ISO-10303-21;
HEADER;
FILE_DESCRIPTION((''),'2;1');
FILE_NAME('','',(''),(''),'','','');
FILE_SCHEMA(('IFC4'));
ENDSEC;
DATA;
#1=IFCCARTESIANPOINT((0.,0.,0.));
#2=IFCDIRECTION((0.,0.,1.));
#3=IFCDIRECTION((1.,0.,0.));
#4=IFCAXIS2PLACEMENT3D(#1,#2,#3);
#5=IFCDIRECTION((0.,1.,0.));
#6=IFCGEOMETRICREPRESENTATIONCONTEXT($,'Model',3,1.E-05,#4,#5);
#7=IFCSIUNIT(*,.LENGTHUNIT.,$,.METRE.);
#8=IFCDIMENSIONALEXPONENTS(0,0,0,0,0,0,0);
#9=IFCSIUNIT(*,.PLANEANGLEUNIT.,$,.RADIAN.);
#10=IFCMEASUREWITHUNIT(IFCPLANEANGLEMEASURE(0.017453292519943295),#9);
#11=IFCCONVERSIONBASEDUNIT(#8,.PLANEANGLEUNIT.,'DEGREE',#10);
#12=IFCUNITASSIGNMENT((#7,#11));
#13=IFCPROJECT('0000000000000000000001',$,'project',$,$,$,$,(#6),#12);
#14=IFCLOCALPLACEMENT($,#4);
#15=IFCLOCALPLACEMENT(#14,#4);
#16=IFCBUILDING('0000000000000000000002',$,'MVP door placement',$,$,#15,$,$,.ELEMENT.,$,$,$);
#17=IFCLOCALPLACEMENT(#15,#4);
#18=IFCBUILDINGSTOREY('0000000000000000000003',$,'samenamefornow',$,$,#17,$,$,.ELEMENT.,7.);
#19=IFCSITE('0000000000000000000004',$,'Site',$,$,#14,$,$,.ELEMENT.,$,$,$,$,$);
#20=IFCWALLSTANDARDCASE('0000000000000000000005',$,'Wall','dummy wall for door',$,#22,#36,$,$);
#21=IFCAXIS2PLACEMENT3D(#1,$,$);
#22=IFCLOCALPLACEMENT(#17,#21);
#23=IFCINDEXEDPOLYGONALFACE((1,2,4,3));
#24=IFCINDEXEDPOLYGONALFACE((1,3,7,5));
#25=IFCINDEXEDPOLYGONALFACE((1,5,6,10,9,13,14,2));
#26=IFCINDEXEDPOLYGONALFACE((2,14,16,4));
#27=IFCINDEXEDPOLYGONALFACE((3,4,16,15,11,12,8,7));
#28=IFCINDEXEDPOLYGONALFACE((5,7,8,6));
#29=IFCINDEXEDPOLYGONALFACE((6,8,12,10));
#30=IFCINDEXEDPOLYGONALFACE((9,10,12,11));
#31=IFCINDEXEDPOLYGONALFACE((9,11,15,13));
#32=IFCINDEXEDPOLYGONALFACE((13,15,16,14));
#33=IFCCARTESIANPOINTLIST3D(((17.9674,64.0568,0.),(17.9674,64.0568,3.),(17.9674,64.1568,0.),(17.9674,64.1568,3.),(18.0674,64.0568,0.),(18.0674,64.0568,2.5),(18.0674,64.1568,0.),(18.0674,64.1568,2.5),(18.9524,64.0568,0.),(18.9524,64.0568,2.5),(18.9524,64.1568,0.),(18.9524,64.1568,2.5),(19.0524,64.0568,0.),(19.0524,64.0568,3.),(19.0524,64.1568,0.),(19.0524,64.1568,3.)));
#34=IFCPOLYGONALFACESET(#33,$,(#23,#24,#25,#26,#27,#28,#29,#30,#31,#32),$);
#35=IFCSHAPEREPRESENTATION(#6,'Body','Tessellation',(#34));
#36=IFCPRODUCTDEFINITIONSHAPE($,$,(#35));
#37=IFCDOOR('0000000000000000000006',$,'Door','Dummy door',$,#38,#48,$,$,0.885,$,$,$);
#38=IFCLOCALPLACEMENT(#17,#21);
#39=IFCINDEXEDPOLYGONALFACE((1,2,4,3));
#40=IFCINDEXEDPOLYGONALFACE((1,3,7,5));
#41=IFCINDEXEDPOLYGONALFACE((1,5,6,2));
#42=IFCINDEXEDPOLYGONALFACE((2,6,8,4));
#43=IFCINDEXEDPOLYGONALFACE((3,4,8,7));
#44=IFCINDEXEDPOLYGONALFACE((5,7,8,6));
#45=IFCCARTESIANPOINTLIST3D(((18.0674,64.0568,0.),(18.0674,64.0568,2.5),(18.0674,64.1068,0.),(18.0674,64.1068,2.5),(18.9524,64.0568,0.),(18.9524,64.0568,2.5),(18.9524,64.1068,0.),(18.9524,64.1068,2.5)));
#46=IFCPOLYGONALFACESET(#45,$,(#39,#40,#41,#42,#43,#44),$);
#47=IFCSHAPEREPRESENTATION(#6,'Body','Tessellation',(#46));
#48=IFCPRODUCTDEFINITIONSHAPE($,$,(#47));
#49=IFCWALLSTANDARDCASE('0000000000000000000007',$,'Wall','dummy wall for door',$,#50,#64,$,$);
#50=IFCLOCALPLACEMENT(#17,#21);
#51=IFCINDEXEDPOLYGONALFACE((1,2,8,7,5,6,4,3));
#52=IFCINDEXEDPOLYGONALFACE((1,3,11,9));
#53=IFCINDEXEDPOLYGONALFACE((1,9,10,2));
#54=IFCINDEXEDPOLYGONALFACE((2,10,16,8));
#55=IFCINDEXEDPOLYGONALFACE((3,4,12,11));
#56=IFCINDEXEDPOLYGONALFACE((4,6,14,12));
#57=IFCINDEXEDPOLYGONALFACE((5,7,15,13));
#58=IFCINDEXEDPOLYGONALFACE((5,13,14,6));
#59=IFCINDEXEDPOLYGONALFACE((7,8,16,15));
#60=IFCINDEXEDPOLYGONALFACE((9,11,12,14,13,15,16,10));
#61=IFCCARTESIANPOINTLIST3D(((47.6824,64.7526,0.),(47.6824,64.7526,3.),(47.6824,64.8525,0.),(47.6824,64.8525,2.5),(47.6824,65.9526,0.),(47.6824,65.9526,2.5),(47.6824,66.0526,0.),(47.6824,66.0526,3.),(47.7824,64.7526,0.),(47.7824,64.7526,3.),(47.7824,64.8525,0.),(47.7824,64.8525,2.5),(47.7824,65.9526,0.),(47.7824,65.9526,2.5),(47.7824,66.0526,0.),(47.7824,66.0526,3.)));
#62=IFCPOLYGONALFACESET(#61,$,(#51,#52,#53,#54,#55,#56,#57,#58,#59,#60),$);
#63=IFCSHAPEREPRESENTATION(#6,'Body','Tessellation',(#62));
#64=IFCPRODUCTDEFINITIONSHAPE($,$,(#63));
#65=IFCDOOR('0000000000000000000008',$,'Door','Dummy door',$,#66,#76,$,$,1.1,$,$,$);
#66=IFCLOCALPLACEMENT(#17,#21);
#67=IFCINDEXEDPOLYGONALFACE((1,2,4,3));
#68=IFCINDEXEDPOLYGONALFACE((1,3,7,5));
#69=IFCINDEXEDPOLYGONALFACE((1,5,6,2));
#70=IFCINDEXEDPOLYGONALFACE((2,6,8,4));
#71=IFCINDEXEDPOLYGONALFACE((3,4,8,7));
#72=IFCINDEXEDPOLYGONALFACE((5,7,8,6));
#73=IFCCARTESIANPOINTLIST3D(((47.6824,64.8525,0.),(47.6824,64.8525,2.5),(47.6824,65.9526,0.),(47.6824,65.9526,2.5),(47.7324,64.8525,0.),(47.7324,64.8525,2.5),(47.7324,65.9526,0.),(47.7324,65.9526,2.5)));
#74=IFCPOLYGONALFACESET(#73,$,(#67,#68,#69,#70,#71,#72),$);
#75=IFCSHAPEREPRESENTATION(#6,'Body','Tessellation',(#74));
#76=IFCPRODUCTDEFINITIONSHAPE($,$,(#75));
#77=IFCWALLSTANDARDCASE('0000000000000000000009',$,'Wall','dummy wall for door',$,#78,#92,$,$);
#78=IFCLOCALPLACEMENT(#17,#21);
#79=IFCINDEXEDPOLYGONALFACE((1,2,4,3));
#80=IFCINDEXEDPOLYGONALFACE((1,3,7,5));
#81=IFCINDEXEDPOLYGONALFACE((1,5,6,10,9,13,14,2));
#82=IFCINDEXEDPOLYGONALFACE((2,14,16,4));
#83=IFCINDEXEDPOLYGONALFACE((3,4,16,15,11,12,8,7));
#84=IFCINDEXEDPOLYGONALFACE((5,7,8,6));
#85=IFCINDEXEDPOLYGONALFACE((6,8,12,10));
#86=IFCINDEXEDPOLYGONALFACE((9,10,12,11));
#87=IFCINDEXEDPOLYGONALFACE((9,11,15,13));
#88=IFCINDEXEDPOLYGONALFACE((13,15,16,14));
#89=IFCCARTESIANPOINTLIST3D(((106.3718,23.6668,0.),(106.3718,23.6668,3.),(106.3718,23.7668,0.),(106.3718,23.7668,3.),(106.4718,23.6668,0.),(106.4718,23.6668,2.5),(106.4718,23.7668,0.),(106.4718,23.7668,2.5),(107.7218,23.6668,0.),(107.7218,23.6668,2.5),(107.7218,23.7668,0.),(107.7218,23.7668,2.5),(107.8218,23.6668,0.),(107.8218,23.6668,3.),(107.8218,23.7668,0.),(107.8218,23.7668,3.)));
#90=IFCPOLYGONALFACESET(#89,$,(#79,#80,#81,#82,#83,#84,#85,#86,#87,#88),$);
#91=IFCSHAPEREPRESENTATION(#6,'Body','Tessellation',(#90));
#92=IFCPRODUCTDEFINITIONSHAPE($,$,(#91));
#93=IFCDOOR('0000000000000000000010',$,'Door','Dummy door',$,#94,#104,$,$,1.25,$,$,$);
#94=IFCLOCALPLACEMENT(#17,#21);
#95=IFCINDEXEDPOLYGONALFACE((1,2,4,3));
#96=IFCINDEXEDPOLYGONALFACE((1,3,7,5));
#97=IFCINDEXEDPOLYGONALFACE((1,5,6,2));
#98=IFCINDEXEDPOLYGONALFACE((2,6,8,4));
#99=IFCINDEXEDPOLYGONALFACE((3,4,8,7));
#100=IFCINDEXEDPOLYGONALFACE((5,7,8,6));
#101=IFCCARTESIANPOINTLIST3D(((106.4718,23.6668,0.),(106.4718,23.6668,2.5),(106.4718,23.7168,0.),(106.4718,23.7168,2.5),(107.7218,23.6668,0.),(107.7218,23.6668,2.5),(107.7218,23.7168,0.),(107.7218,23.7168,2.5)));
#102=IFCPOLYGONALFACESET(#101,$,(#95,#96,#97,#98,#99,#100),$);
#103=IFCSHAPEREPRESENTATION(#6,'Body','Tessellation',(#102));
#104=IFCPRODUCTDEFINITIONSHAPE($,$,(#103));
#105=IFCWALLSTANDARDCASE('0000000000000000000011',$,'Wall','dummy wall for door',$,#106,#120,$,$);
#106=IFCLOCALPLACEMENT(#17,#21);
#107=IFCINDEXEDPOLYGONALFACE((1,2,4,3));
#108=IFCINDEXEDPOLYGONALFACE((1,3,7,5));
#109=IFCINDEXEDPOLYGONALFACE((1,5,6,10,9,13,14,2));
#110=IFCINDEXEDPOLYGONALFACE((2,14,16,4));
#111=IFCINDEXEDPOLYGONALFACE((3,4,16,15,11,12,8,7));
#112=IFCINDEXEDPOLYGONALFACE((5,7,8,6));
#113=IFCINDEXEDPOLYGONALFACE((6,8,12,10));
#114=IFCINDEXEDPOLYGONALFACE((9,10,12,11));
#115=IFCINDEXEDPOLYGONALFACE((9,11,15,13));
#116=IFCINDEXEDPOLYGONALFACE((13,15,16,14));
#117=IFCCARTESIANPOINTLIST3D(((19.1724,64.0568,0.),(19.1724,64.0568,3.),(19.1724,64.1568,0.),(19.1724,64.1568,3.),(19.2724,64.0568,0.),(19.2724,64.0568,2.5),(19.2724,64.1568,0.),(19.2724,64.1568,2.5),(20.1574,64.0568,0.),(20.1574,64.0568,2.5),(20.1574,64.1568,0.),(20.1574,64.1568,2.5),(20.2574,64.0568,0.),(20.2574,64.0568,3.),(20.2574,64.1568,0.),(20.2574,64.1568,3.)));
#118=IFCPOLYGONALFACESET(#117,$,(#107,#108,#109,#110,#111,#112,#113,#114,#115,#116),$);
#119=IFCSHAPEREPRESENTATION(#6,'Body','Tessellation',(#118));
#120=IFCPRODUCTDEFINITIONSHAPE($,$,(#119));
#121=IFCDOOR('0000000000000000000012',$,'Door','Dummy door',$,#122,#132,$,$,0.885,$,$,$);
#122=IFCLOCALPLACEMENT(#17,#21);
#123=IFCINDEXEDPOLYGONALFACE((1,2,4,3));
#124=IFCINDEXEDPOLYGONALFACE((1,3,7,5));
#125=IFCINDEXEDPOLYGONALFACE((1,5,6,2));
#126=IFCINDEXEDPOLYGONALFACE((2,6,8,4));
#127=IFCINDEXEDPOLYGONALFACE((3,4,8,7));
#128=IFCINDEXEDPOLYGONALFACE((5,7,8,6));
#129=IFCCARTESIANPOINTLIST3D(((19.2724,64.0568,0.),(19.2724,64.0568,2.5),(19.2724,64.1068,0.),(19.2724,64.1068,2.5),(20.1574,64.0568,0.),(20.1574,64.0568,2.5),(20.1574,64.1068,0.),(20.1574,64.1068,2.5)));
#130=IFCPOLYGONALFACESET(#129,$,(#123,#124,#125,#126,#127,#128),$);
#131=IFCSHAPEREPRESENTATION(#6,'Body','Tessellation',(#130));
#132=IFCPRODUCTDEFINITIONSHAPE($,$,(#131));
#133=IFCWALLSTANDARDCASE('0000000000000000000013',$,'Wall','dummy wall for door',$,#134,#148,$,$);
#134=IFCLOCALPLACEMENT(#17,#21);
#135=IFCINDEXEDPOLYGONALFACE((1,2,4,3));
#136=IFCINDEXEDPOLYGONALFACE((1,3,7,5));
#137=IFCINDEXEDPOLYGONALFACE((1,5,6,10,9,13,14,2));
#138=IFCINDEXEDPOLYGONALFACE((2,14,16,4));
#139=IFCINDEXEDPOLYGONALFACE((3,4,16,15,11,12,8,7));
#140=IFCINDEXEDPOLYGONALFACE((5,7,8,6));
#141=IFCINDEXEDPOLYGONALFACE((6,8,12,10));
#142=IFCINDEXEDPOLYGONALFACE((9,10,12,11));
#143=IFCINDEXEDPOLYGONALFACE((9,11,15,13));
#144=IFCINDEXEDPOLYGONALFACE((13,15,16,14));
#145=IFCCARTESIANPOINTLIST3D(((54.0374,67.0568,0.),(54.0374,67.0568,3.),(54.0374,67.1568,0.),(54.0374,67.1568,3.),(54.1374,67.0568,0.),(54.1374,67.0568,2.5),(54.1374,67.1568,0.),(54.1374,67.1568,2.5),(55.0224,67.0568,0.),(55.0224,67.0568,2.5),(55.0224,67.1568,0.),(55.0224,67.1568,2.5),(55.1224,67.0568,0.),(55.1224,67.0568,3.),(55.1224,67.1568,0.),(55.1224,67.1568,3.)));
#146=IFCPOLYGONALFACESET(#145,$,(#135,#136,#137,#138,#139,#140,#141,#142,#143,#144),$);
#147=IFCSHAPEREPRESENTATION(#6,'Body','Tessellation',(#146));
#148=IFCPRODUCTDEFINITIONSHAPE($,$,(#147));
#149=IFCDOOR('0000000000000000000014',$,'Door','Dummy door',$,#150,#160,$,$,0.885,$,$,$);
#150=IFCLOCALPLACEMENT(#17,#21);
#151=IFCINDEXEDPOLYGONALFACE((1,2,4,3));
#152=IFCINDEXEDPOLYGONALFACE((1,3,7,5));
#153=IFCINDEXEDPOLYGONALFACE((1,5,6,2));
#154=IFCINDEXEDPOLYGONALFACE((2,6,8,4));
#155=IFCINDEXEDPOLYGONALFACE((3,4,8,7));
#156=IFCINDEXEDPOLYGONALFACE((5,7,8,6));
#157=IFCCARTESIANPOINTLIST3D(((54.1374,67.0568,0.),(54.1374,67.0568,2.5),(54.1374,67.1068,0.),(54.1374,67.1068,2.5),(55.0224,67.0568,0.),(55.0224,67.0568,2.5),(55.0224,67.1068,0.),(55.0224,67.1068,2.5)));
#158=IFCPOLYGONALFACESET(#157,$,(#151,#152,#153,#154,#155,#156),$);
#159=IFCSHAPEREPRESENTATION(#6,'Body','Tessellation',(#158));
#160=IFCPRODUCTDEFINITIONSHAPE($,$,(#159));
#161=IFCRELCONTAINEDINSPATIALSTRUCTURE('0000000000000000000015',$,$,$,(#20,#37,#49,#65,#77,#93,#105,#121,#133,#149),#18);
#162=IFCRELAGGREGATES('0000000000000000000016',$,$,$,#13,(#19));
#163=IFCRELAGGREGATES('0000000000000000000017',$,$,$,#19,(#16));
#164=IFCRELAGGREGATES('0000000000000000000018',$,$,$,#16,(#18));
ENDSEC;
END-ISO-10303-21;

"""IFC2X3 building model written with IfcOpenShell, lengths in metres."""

from ifc_helpers import new_model, entity, si_unit, converted_unit, direction, origin_with_axes, place, context, project, spatial, polyline, outline, extrude, element, fill, save


model = new_model("IFC2X3")

# Units and contexts
model_context = context("Model", 3, precision=1e-05, world=origin_with_axes(), true_north=direction((0.0, 1.0, 0.0)))
ifc_project = project(units=[si_unit("LENGTHUNIT", "METRE"), converted_unit("PLANEANGLEUNIT", "DEGREE", entity("IfcPlaneAngleMeasure", 0.017453292519943295), si_unit("PLANEANGLEUNIT", "RADIAN"), dimensions=[0, 0, 0, 0, 0, 0, 0])], contexts=[model_context])

# Site, building, storey
site_placement = place(None, origin_with_axes())
site = spatial("IfcSite", under=ifc_project, at=site_placement, Name="Site", CompositionType="ELEMENT")
building_placement = place(site_placement, origin_with_axes())
building = spatial("IfcBuilding", under=site, at=building_placement, Name="MVP door placement", CompositionType="ELEMENT")
storey_placement = place(building_placement, origin_with_axes())
storey = spatial("IfcBuildingStorey", under=building, at=storey_placement, Name="samenamefornow", CompositionType="ELEMENT", Elevation=7.0)

# Walls, openings, doors
wall_1_placement = place(storey_placement, origin_with_axes())
wall_1 = element("IfcWallStandardCase", 1, at=wall_1_placement, inside=storey, Name="Wall", Description="dummy wall for door", context=model_context, shape_type="SweptSolid", body=[
    extrude(outline(polyline([(17.9674, 64.0568, 0.0), (19.0524, 64.0568, 0.0), (19.0524, 64.1568, 0.0), (17.9674, 64.1568, 0.0), (17.9674, 64.0568, 0.0)])), origin_with_axes(), (0.0, 0.0, 1.0), 3.0),
])
opening_1_placement = place(wall_1_placement, origin_with_axes())
opening_1 = element("IfcOpeningElement", 2, at=opening_1_placement, cuts=wall_1, context=model_context, shape_type="SweptSolid", body=[
    extrude(outline(polyline([(18.0674, 64.0568, 0.0), (18.9524, 64.0568, 0.0), (18.9524, 64.1568, 0.0), (18.0674, 64.1568, 0.0), (18.0674, 64.0568, 0.0)])), origin_with_axes(), (0.0, 0.0, 1.0), 2.5),
])
door_1_placement = place(opening_1_placement, origin_with_axes())
door_1 = element("IfcDoor", 3, at=door_1_placement, inside=storey, Name="Door", Description="Dummy door", OverallWidth=0.885, context=model_context, shape_type="SweptSolid", body=[
    extrude(outline(polyline([(18.0674, 64.0568, 0.0), (18.9524, 64.0568, 0.0), (18.9524, 64.1068, 0.0), (18.0674, 64.1068, 0.0), (18.0674, 64.0568, 0.0)])), origin_with_axes(), (0.0, 0.0, 1.0), 2.5),
])
fill(opening_1, door_1)
wall_2_placement = place(storey_placement, origin_with_axes())
wall_2 = element("IfcWallStandardCase", 4, at=wall_2_placement, inside=storey, Name="Wall", Description="dummy wall for door", context=model_context, shape_type="SweptSolid", body=[
    extrude(outline(polyline([(47.6824, 66.0525, 0.0), (47.6824, 64.7525, 0.0), (47.7824, 64.7525, 0.0), (47.7824, 66.0525, 0.0), (47.6824, 66.0525, 0.0)])), origin_with_axes(), (0.0, 0.0, 1.0), 3.0),
])
opening_2_placement = place(wall_2_placement, origin_with_axes())
opening_2 = element("IfcOpeningElement", 5, at=opening_2_placement, cuts=wall_2, context=model_context, shape_type="SweptSolid", body=[
    extrude(outline(polyline([(47.6824, 65.9526, 0.0), (47.6824, 64.8525, 0.0), (47.7824, 64.8525, 0.0), (47.7824, 65.9526, 0.0), (47.6824, 65.9526, 0.0)])), origin_with_axes(), (0.0, 0.0, 1.0), 2.5),
])
door_2_placement = place(opening_2_placement, origin_with_axes())
door_2 = element("IfcDoor", 6, at=door_2_placement, inside=storey, Name="Door", Description="Dummy door", OverallWidth=1.1, context=model_context, shape_type="SweptSolid", body=[
    extrude(outline(polyline([(47.6824, 65.9526, 0.0), (47.6824, 64.8525, 0.0), (47.7324, 64.8525, 0.0), (47.7324, 65.9526, 0.0), (47.6824, 65.9526, 0.0)])), origin_with_axes(), (0.0, 0.0, 1.0), 2.5),
])
fill(opening_2, door_2)
wall_3_placement = place(storey_placement, origin_with_axes())
wall_3 = element("IfcWallStandardCase", 7, at=wall_3_placement, inside=storey, Name="Wall", Description="dummy wall for door", context=model_context, shape_type="SweptSolid", body=[
    extrude(outline(polyline([(106.3718, 23.6668, 0.0), (107.8218, 23.6668, 0.0), (107.8218, 23.7668, 0.0), (106.3718, 23.7668, 0.0), (106.3718, 23.6668, 0.0)])), origin_with_axes(), (0.0, 0.0, 1.0), 3.0),
])
opening_3_placement = place(wall_3_placement, origin_with_axes())
opening_3 = element("IfcOpeningElement", 8, at=opening_3_placement, cuts=wall_3, context=model_context, shape_type="SweptSolid", body=[
    extrude(outline(polyline([(106.4718, 23.6668, 0.0), (107.7218, 23.6668, 0.0), (107.7218, 23.7668, 0.0), (106.4718, 23.7668, 0.0), (106.4718, 23.6668, 0.0)])), origin_with_axes(), (0.0, 0.0, 1.0), 2.5),
])
door_3_placement = place(opening_3_placement, origin_with_axes())
door_3 = element("IfcDoor", 9, at=door_3_placement, inside=storey, Name="Door", Description="Dummy door", OverallWidth=1.25, context=model_context, shape_type="SweptSolid", body=[
    extrude(outline(polyline([(106.4718, 23.6668, 0.0), (107.7218, 23.6668, 0.0), (107.7218, 23.7168, 0.0), (106.4718, 23.7168, 0.0), (106.4718, 23.6668, 0.0)])), origin_with_axes(), (0.0, 0.0, 1.0), 2.5),
])
fill(opening_3, door_3)
wall_4_placement = place(storey_placement, origin_with_axes())
wall_4 = element("IfcWallStandardCase", 10, at=wall_4_placement, inside=storey, Name="Wall", Description="dummy wall for door", context=model_context, shape_type="SweptSolid", body=[
    extrude(outline(polyline([(20.2574, 64.0568, 0.0), (19.1724, 64.0568, 0.0), (19.1724, 64.1568, 0.0), (20.2574, 64.1568, 0.0), (20.2574, 64.0568, 0.0)])), origin_with_axes(), (0.0, 0.0, 1.0), 3.0),
])
opening_4_placement = place(wall_4_placement, origin_with_axes())
opening_4 = element("IfcOpeningElement", 11, at=opening_4_placement, cuts=wall_4, context=model_context, shape_type="SweptSolid", body=[
    extrude(outline(polyline([(20.1574, 64.0568, 0.0), (19.2724, 64.0568, 0.0), (19.2724, 64.1568, 0.0), (20.1574, 64.1568, 0.0), (20.1574, 64.0568, 0.0)])), origin_with_axes(), (0.0, 0.0, 1.0), 2.5),
])
door_4_placement = place(opening_4_placement, origin_with_axes())
door_4 = element("IfcDoor", 12, at=door_4_placement, inside=storey, Name="Door", Description="Dummy door", OverallWidth=0.885, context=model_context, shape_type="SweptSolid", body=[
    extrude(outline(polyline([(20.1574, 64.0568, 0.0), (19.2724, 64.0568, 0.0), (19.2724, 64.1068, 0.0), (20.1574, 64.1068, 0.0), (20.1574, 64.0568, 0.0)])), origin_with_axes(), (0.0, 0.0, 1.0), 2.5),
])
fill(opening_4, door_4)
wall_5_placement = place(storey_placement, origin_with_axes())
wall_5 = element("IfcWallStandardCase", 13, at=wall_5_placement, inside=storey, Name="Wall", Description="dummy wall for door", context=model_context, shape_type="SweptSolid", body=[
    extrude(outline(polyline([(54.0374, 67.0568, 0.0), (55.1224, 67.0568, 0.0), (55.1224, 67.1568, 0.0), (54.0374, 67.1568, 0.0), (54.0374, 67.0568, 0.0)])), origin_with_axes(), (0.0, 0.0, 1.0), 3.0),
])
opening_5_placement = place(wall_5_placement, origin_with_axes())
opening_5 = element("IfcOpeningElement", 14, at=opening_5_placement, cuts=wall_5, context=model_context, shape_type="SweptSolid", body=[
    extrude(outline(polyline([(54.1374, 67.0568, 0.0), (55.0224, 67.0568, 0.0), (55.0224, 67.1568, 0.0), (54.1374, 67.1568, 0.0), (54.1374, 67.0568, 0.0)])), origin_with_axes(), (0.0, 0.0, 1.0), 2.5),
])
door_5_placement = place(opening_5_placement, origin_with_axes())
door_5 = element("IfcDoor", 15, at=door_5_placement, inside=storey, Name="Door", Description="Dummy door", OverallWidth=0.885, context=model_context, shape_type="SweptSolid", body=[
    extrude(outline(polyline([(54.1374, 67.0568, 0.0), (55.0224, 67.0568, 0.0), (55.0224, 67.1068, 0.0), (54.1374, 67.1068, 0.0), (54.1374, 67.0568, 0.0)])), origin_with_axes(), (0.0, 0.0, 1.0), 2.5),
])
fill(opening_5, door_5)

save(model, "model.ifc")
